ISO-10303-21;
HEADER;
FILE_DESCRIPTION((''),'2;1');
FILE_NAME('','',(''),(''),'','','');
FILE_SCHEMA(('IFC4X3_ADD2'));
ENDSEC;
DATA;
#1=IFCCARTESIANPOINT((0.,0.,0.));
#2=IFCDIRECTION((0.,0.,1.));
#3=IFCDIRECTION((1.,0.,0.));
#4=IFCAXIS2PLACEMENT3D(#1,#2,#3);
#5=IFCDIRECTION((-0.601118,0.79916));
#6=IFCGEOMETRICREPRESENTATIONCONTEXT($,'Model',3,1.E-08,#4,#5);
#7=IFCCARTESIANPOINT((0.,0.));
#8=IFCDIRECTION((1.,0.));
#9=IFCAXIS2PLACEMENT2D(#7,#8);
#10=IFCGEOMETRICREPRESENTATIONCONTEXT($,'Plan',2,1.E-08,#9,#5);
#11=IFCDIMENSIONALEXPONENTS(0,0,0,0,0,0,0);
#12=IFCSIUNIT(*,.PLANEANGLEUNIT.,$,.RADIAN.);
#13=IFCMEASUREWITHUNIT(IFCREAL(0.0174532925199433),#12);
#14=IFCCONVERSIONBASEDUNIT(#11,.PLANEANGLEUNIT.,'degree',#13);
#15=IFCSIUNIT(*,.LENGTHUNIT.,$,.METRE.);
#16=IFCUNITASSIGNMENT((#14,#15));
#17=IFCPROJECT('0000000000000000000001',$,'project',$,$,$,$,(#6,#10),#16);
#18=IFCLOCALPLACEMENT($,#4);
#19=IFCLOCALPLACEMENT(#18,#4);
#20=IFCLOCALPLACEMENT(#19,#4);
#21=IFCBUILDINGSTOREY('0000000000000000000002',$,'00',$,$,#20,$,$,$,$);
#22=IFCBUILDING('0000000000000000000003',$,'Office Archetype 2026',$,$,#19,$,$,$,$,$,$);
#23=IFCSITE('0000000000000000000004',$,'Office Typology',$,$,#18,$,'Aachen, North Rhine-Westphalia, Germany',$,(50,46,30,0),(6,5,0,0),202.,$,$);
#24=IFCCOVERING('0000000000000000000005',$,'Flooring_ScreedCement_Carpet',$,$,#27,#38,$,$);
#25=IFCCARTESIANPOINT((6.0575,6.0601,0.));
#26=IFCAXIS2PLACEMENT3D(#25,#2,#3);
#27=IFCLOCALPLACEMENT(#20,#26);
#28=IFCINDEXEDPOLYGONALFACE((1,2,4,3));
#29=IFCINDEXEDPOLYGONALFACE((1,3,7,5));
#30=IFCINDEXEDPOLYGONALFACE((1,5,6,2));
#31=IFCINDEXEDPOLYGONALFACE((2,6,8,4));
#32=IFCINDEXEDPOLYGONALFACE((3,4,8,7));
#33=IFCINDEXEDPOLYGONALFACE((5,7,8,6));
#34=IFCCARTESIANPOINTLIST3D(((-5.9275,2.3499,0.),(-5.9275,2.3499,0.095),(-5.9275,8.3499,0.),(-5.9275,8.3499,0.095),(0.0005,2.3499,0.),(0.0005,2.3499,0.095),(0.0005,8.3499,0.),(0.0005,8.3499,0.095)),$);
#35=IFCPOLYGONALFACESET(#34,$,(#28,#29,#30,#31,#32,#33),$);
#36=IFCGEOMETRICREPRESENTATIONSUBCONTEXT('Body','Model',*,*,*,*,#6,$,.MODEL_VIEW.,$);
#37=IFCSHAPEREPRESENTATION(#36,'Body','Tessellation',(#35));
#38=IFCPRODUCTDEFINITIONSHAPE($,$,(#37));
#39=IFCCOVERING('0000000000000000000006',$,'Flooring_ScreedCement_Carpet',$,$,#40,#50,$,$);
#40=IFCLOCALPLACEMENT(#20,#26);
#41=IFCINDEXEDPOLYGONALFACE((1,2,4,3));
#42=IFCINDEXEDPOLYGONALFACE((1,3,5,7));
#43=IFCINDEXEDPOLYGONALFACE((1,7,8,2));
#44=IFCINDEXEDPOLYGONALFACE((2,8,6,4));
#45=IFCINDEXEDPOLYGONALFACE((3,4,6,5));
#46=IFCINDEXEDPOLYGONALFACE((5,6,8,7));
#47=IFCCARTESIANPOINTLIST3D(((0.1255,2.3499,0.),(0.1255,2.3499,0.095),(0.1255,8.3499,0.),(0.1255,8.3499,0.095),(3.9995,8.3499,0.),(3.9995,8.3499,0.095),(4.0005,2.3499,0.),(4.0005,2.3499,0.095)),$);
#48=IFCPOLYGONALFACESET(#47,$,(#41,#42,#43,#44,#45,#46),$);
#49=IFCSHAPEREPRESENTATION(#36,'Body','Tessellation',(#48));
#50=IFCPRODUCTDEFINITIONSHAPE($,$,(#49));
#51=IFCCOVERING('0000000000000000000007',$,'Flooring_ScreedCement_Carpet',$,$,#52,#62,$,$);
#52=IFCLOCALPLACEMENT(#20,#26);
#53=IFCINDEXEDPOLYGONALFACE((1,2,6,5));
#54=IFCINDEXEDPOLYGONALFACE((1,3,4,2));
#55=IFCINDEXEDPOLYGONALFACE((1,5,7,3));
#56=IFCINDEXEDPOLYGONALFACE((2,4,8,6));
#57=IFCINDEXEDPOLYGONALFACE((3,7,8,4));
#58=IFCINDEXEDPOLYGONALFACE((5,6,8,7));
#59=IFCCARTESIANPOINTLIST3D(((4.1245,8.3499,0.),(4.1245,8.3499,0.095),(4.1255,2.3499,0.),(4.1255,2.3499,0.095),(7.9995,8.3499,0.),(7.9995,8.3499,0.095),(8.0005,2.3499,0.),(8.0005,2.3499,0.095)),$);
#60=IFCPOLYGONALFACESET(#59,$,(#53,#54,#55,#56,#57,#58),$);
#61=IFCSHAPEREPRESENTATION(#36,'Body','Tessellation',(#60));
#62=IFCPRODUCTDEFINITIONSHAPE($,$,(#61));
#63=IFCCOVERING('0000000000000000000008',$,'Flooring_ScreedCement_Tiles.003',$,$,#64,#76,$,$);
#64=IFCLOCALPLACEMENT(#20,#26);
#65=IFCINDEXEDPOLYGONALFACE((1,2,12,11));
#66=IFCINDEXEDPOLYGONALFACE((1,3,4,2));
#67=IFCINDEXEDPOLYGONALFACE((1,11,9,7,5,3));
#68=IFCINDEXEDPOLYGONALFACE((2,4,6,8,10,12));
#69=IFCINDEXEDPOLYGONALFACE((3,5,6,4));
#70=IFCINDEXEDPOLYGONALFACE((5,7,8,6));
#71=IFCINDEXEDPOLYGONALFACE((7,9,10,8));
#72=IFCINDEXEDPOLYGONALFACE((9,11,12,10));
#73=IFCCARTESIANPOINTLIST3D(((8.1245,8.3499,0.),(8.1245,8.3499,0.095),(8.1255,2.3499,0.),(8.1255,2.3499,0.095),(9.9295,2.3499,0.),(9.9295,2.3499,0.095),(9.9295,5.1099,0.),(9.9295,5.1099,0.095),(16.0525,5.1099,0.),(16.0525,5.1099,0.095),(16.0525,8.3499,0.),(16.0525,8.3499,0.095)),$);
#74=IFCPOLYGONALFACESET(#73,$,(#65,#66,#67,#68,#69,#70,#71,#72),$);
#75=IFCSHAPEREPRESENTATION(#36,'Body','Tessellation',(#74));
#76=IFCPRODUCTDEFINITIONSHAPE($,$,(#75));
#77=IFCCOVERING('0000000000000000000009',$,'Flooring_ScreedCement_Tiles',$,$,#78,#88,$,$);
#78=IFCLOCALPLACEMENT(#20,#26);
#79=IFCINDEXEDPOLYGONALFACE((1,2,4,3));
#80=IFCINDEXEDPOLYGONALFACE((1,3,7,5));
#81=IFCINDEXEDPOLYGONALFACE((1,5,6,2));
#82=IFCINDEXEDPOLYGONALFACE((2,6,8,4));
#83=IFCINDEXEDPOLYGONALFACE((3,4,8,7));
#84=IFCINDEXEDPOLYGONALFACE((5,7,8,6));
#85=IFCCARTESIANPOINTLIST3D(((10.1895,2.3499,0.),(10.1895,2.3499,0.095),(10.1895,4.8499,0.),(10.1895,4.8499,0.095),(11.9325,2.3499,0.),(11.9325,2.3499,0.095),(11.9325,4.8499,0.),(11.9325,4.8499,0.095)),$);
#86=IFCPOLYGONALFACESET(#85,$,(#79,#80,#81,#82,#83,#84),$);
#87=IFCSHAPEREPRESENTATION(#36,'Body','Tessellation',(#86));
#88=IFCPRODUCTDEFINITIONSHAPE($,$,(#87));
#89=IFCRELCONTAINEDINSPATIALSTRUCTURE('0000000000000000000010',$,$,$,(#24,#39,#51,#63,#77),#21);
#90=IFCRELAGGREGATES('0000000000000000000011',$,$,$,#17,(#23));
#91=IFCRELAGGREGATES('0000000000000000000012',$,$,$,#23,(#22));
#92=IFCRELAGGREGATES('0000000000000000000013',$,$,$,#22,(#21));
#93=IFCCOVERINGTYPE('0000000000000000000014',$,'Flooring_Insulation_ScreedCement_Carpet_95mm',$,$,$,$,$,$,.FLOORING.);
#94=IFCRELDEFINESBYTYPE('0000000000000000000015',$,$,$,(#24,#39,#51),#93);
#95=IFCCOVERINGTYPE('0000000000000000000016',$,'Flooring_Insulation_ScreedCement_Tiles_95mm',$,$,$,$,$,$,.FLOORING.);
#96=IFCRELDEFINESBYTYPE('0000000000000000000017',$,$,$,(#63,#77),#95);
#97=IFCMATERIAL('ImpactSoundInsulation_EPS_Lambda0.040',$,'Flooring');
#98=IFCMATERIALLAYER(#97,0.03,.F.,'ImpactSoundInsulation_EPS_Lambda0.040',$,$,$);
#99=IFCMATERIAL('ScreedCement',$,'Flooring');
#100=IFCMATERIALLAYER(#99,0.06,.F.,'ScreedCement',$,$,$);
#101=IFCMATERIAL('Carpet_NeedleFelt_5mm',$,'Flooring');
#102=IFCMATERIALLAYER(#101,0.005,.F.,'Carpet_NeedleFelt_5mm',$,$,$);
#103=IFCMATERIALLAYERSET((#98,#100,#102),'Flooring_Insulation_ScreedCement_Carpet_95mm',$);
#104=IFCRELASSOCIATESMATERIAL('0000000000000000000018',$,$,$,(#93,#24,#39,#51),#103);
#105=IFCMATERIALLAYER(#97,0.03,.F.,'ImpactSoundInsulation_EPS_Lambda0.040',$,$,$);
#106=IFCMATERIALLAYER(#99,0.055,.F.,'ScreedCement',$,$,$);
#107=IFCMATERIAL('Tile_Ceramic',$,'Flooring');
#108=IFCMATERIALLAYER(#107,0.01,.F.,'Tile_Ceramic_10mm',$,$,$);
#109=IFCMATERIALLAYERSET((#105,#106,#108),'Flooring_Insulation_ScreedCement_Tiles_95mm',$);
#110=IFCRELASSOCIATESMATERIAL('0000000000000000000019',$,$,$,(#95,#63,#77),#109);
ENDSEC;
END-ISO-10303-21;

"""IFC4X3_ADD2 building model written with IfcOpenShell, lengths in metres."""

from ifc_helpers import new_model, entity, si_unit, converted_unit, direction, frame, origin_with_axes, origin_2d_with_axis, place, context, subcontext, project, spatial, line, indexed_curve, outline, extrude, material, layer, layer_set, layer_usage, type_object, element, save


model = new_model("IFC4X3_ADD2")

# Units and contexts
model_context = context("Model", 3, precision=1e-08, world=origin_with_axes(), true_north=direction((-0.601118, 0.79916)))
plan_context = context("Plan", 2, precision=1e-08, world=origin_2d_with_axis(), true_north=direction((-0.601118, 0.79916)))
body_context = subcontext(model_context, "Body", "Model", "MODEL_VIEW")
ifc_project = project(units=[converted_unit("PLANEANGLEUNIT", "degree", entity("IfcReal", 0.0174532925199433), si_unit("PLANEANGLEUNIT", "RADIAN"), dimensions=[0, 0, 0, 0, 0, 0, 0]), si_unit("LENGTHUNIT", "METRE")], contexts=[model_context, plan_context])

# Site, building, storey
site_placement = place(None, origin_with_axes())
site = spatial("IfcSite", under=ifc_project, at=site_placement, Name="Office Typology", LongName="Aachen, North Rhine-Westphalia, Germany", RefLatitude=(50, 46, 30, 0), RefLongitude=(6, 5, 0, 0), RefElevation=202.0)
building_placement = place(site_placement, origin_with_axes())
building = spatial("IfcBuilding", under=site, at=building_placement, Name="Office Archetype 2026")
storey_placement = place(building_placement, origin_with_axes())
storey = spatial("IfcBuildingStorey", under=building, at=storey_placement, Name="00")

# Coverings
ifc_material_1 = material(Name="ImpactSoundInsulation_EPS_Lambda0.040", Category="Flooring")
ifc_layer_1 = layer(ifc_material_1, 0.03, ventilated=False, Name="ImpactSoundInsulation_EPS_Lambda0.040")
ifc_material_2 = material(Name="ScreedCement", Category="Flooring")
ifc_layer_2 = layer(ifc_material_2, 0.06, ventilated=False, Name="ScreedCement")
ifc_material_3 = material(Name="Carpet_NeedleFelt_5mm", Category="Flooring")
ifc_layer_3 = layer(ifc_material_3, 0.005, ventilated=False, Name="Carpet_NeedleFelt_5mm")
ifc_layer_set_1 = layer_set([ifc_layer_1, ifc_layer_2, ifc_layer_3], Name="Flooring_Insulation_ScreedCement_Carpet_95mm")
ifc_layer_usage_1 = layer_usage(ifc_layer_set_1, "AXIS3", "POSITIVE", 0.0)
covering_type_1 = type_object("IfcCoveringType", Name="Flooring_Insulation_ScreedCement_Carpet_95mm", PredefinedType="FLOORING", material=ifc_layer_set_1)
covering_1_placement = place(storey_placement, frame((6.0575, 6.0601, 0.0), z_axis=(0.0, 0.0, 1.0), x_axis=(1.0, 0.0, 0.0)))
element("IfcCovering", 1, at=covering_1_placement, inside=storey, type_object=covering_type_1, material=ifc_layer_usage_1, Name="Flooring_ScreedCement_Carpet", context=body_context, shape_type="SweptSolid", body=[
    extrude(outline(indexed_curve([(-5.9275, 2.3499), (-5.9275, 8.3499), (0.0005, 8.3499), (0.0005, 2.3499)], segments=[line(1, 2, 3, 4, 1)])), origin_with_axes(), (0.0, 0.0, 1.0), 0.095),
])
ifc_layer_usage_2 = layer_usage(ifc_layer_set_1, "AXIS3", "POSITIVE", 0.0)
covering_2_placement = place(storey_placement, frame((6.0575, 6.0601, 0.0), z_axis=(0.0, 0.0, 1.0), x_axis=(1.0, 0.0, 0.0)))
element("IfcCovering", 2, at=covering_2_placement, inside=storey, type_object=covering_type_1, material=ifc_layer_usage_2, Name="Flooring_ScreedCement_Carpet", context=body_context, shape_type="SweptSolid", body=[
    extrude(outline(indexed_curve([(0.1255, 2.3499), (0.1255, 8.3499), (3.9995, 8.3499), (4.0005, 2.3499)], segments=[line(1, 2, 3, 4, 1)])), origin_with_axes(), (0.0, 0.0, 1.0), 0.095),
])
ifc_layer_usage_3 = layer_usage(ifc_layer_set_1, "AXIS3", "POSITIVE", 0.0)
covering_3_placement = place(storey_placement, frame((6.0575, 6.0601, 0.0), z_axis=(0.0, 0.0, 1.0), x_axis=(1.0, 0.0, 0.0)))
element("IfcCovering", 3, at=covering_3_placement, inside=storey, type_object=covering_type_1, material=ifc_layer_usage_3, Name="Flooring_ScreedCement_Carpet", context=body_context, shape_type="SweptSolid", body=[
    extrude(outline(indexed_curve([(4.1255, 2.3499), (4.1245, 8.3499), (7.9995, 8.3499), (8.0005, 2.3499)], segments=[line(1, 2, 3, 4, 1)])), origin_with_axes(), (0.0, 0.0, 1.0), 0.095),
])
ifc_layer_4 = layer(ifc_material_1, 0.03, ventilated=False, Name="ImpactSoundInsulation_EPS_Lambda0.040")
ifc_layer_5 = layer(ifc_material_2, 0.055, ventilated=False, Name="ScreedCement")
ifc_material_4 = material(Name="Tile_Ceramic", Category="Flooring")
ifc_layer_6 = layer(ifc_material_4, 0.01, ventilated=False, Name="Tile_Ceramic_10mm")
ifc_layer_set_2 = layer_set([ifc_layer_4, ifc_layer_5, ifc_layer_6], Name="Flooring_Insulation_ScreedCement_Tiles_95mm")
ifc_layer_usage_4 = layer_usage(ifc_layer_set_2, "AXIS3", "POSITIVE", 0.0)
covering_type_2 = type_object("IfcCoveringType", Name="Flooring_Insulation_ScreedCement_Tiles_95mm", PredefinedType="FLOORING", material=ifc_layer_set_2)
covering_4_placement = place(storey_placement, frame((6.0575, 6.0601, 0.0), z_axis=(0.0, 0.0, 1.0), x_axis=(1.0, 0.0, 0.0)))
element("IfcCovering", 4, at=covering_4_placement, inside=storey, type_object=covering_type_2, material=ifc_layer_usage_4, Name="Flooring_ScreedCement_Tiles.003", context=body_context, shape_type="SweptSolid", body=[
    extrude(outline(indexed_curve([(9.9295, 2.3499), (8.1255, 2.3499), (8.1245, 8.3499), (16.0525, 8.3499), (16.0525, 5.1099), (9.9295, 5.1099)], segments=[line(1, 2, 3, 4, 5, 6, 1)])), None, (0.0, 0.0, 1.0), 0.095),
])
ifc_layer_usage_5 = layer_usage(ifc_layer_set_2, "AXIS3", "POSITIVE", 0.0)
covering_5_placement = place(storey_placement, frame((6.0575, 6.0601, 0.0), z_axis=(0.0, 0.0, 1.0), x_axis=(1.0, 0.0, 0.0)))
element("IfcCovering", 5, at=covering_5_placement, inside=storey, type_object=covering_type_2, material=ifc_layer_usage_5, Name="Flooring_ScreedCement_Tiles", context=body_context, shape_type="SweptSolid", body=[
    extrude(outline(indexed_curve([(11.9325, 4.8499), (11.9325, 2.3499), (10.1895, 2.3499), (10.1895, 4.8499)], segments=[line(1, 2, 3, 4, 1)])), origin_with_axes(), (0.0, 0.0, 1.0), 0.095),
])

save(model, "model.ifc")
